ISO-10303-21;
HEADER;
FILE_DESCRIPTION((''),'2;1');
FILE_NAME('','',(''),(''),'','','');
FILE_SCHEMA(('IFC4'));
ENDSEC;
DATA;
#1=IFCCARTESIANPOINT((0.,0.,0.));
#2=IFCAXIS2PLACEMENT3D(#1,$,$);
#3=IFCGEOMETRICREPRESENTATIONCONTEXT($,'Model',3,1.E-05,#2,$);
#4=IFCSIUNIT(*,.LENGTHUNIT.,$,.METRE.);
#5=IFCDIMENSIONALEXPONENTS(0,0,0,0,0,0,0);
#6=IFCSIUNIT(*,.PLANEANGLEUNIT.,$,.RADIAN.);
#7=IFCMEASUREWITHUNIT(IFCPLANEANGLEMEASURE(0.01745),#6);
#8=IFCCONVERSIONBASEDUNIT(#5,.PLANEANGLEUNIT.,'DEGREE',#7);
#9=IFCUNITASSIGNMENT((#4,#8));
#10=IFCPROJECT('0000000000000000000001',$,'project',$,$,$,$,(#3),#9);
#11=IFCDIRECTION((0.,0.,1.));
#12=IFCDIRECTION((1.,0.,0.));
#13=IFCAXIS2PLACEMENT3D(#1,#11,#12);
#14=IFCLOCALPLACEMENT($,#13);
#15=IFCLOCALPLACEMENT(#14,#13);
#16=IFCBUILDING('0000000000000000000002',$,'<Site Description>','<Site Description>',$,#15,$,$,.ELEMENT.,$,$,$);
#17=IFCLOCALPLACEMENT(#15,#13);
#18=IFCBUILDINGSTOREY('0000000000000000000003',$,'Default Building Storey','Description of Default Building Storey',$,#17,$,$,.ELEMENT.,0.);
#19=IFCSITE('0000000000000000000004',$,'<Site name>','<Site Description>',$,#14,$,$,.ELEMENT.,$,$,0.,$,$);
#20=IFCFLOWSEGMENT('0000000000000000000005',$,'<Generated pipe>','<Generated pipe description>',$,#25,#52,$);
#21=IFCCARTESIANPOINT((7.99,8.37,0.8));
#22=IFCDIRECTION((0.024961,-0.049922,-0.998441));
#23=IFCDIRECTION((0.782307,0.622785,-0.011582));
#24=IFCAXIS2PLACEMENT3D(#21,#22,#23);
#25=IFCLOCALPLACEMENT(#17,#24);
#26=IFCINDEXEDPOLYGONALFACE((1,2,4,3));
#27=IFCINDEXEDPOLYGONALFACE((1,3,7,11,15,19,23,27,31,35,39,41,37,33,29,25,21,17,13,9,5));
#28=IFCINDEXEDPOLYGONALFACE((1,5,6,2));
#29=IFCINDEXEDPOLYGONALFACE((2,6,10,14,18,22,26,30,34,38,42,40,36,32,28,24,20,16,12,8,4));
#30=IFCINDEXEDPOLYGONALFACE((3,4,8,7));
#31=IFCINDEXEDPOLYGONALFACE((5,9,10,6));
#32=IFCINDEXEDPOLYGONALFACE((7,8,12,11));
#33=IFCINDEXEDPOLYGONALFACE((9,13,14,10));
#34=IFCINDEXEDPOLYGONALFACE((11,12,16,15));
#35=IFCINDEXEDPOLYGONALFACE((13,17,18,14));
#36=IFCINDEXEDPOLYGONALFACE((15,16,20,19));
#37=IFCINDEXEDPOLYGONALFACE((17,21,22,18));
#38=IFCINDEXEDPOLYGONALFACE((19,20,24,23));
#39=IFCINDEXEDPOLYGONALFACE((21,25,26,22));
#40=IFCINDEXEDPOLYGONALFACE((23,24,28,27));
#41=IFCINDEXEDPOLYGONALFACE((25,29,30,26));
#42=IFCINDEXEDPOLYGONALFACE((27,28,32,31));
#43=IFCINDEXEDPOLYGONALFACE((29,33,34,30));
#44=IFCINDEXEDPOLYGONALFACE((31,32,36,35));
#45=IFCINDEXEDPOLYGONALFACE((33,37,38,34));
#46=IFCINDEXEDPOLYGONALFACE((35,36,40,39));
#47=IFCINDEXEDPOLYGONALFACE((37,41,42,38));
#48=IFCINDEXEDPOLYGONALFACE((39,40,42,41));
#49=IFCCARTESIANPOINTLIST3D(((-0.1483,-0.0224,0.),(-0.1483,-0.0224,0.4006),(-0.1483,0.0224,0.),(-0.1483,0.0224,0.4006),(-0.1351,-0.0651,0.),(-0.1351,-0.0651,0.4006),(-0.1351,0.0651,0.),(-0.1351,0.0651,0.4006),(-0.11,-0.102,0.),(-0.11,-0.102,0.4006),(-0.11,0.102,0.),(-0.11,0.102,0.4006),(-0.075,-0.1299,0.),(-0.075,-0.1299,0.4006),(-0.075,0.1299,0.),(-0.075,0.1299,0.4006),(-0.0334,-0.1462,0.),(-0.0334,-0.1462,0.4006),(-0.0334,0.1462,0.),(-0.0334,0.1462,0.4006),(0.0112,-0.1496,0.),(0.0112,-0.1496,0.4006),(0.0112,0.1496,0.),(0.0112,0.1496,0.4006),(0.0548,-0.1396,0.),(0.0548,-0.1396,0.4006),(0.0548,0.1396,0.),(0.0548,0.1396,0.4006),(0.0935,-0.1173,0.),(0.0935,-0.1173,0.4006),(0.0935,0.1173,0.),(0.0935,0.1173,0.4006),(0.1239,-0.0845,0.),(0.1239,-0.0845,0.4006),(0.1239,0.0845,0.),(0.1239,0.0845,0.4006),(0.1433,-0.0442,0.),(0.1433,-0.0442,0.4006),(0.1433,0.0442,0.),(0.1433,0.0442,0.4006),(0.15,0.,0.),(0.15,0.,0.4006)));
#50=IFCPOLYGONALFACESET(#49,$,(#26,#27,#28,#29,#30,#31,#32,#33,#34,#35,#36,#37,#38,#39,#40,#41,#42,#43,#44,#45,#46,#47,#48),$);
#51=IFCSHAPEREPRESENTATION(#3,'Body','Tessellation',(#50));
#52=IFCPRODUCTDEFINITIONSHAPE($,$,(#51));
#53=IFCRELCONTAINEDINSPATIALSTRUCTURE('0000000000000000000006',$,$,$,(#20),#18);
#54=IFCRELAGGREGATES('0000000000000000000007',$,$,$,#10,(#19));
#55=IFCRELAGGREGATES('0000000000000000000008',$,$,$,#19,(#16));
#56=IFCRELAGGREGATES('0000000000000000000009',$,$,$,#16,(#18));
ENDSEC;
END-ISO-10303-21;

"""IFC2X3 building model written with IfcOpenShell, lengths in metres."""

from ifc_helpers import new_model, entity, si_unit, converted_unit, frame, origin, origin_with_axes, origin_2d_with_axis, place, context, project, spatial, circle, extrude, element, save


model = new_model("IFC2X3")

# Units and contexts
model_context = context("Model", 3, precision=1e-05, world=origin())
ifc_project = project(units=[si_unit("LENGTHUNIT", "METRE"), converted_unit("PLANEANGLEUNIT", "DEGREE", entity("IfcPlaneAngleMeasure", 0.01745), si_unit("PLANEANGLEUNIT", "RADIAN"), dimensions=[0, 0, 0, 0, 0, 0, 0])], contexts=[model_context])

# Site, building, storey
site_placement = place(None, origin_with_axes())
site = spatial("IfcSite", under=ifc_project, at=site_placement, Name="<Site name>", Description="<Site Description>", CompositionType="ELEMENT", RefElevation=0.0)
building_placement = place(site_placement, origin_with_axes())
building = spatial("IfcBuilding", under=site, at=building_placement, Name="<Site Description>", Description="<Site Description>", CompositionType="ELEMENT")
storey_placement = place(building_placement, origin_with_axes())
storey = spatial("IfcBuildingStorey", under=building, at=storey_placement, Name="Default Building Storey", Description="Description of Default Building Storey", CompositionType="ELEMENT", Elevation=0.0)

# Flow segment
flow_segment_1_placement = place(storey_placement, frame((7.99, 8.37, 0.8), z_axis=(0.024961, -0.049922, -0.998441), x_axis=(0.782307, 0.622785, -0.011582)))
element("IfcFlowSegment", 1, at=flow_segment_1_placement, inside=storey, Name="<Generated pipe>", Description="<Generated pipe description>", context=model_context, shape_type="SweptSolid", body=[
    extrude(circle(Radius=0.15, at=origin_2d_with_axis()), origin_with_axes(), (0.0, 0.0, 1.0), 0.4006),
])

save(model, "model.ifc")
